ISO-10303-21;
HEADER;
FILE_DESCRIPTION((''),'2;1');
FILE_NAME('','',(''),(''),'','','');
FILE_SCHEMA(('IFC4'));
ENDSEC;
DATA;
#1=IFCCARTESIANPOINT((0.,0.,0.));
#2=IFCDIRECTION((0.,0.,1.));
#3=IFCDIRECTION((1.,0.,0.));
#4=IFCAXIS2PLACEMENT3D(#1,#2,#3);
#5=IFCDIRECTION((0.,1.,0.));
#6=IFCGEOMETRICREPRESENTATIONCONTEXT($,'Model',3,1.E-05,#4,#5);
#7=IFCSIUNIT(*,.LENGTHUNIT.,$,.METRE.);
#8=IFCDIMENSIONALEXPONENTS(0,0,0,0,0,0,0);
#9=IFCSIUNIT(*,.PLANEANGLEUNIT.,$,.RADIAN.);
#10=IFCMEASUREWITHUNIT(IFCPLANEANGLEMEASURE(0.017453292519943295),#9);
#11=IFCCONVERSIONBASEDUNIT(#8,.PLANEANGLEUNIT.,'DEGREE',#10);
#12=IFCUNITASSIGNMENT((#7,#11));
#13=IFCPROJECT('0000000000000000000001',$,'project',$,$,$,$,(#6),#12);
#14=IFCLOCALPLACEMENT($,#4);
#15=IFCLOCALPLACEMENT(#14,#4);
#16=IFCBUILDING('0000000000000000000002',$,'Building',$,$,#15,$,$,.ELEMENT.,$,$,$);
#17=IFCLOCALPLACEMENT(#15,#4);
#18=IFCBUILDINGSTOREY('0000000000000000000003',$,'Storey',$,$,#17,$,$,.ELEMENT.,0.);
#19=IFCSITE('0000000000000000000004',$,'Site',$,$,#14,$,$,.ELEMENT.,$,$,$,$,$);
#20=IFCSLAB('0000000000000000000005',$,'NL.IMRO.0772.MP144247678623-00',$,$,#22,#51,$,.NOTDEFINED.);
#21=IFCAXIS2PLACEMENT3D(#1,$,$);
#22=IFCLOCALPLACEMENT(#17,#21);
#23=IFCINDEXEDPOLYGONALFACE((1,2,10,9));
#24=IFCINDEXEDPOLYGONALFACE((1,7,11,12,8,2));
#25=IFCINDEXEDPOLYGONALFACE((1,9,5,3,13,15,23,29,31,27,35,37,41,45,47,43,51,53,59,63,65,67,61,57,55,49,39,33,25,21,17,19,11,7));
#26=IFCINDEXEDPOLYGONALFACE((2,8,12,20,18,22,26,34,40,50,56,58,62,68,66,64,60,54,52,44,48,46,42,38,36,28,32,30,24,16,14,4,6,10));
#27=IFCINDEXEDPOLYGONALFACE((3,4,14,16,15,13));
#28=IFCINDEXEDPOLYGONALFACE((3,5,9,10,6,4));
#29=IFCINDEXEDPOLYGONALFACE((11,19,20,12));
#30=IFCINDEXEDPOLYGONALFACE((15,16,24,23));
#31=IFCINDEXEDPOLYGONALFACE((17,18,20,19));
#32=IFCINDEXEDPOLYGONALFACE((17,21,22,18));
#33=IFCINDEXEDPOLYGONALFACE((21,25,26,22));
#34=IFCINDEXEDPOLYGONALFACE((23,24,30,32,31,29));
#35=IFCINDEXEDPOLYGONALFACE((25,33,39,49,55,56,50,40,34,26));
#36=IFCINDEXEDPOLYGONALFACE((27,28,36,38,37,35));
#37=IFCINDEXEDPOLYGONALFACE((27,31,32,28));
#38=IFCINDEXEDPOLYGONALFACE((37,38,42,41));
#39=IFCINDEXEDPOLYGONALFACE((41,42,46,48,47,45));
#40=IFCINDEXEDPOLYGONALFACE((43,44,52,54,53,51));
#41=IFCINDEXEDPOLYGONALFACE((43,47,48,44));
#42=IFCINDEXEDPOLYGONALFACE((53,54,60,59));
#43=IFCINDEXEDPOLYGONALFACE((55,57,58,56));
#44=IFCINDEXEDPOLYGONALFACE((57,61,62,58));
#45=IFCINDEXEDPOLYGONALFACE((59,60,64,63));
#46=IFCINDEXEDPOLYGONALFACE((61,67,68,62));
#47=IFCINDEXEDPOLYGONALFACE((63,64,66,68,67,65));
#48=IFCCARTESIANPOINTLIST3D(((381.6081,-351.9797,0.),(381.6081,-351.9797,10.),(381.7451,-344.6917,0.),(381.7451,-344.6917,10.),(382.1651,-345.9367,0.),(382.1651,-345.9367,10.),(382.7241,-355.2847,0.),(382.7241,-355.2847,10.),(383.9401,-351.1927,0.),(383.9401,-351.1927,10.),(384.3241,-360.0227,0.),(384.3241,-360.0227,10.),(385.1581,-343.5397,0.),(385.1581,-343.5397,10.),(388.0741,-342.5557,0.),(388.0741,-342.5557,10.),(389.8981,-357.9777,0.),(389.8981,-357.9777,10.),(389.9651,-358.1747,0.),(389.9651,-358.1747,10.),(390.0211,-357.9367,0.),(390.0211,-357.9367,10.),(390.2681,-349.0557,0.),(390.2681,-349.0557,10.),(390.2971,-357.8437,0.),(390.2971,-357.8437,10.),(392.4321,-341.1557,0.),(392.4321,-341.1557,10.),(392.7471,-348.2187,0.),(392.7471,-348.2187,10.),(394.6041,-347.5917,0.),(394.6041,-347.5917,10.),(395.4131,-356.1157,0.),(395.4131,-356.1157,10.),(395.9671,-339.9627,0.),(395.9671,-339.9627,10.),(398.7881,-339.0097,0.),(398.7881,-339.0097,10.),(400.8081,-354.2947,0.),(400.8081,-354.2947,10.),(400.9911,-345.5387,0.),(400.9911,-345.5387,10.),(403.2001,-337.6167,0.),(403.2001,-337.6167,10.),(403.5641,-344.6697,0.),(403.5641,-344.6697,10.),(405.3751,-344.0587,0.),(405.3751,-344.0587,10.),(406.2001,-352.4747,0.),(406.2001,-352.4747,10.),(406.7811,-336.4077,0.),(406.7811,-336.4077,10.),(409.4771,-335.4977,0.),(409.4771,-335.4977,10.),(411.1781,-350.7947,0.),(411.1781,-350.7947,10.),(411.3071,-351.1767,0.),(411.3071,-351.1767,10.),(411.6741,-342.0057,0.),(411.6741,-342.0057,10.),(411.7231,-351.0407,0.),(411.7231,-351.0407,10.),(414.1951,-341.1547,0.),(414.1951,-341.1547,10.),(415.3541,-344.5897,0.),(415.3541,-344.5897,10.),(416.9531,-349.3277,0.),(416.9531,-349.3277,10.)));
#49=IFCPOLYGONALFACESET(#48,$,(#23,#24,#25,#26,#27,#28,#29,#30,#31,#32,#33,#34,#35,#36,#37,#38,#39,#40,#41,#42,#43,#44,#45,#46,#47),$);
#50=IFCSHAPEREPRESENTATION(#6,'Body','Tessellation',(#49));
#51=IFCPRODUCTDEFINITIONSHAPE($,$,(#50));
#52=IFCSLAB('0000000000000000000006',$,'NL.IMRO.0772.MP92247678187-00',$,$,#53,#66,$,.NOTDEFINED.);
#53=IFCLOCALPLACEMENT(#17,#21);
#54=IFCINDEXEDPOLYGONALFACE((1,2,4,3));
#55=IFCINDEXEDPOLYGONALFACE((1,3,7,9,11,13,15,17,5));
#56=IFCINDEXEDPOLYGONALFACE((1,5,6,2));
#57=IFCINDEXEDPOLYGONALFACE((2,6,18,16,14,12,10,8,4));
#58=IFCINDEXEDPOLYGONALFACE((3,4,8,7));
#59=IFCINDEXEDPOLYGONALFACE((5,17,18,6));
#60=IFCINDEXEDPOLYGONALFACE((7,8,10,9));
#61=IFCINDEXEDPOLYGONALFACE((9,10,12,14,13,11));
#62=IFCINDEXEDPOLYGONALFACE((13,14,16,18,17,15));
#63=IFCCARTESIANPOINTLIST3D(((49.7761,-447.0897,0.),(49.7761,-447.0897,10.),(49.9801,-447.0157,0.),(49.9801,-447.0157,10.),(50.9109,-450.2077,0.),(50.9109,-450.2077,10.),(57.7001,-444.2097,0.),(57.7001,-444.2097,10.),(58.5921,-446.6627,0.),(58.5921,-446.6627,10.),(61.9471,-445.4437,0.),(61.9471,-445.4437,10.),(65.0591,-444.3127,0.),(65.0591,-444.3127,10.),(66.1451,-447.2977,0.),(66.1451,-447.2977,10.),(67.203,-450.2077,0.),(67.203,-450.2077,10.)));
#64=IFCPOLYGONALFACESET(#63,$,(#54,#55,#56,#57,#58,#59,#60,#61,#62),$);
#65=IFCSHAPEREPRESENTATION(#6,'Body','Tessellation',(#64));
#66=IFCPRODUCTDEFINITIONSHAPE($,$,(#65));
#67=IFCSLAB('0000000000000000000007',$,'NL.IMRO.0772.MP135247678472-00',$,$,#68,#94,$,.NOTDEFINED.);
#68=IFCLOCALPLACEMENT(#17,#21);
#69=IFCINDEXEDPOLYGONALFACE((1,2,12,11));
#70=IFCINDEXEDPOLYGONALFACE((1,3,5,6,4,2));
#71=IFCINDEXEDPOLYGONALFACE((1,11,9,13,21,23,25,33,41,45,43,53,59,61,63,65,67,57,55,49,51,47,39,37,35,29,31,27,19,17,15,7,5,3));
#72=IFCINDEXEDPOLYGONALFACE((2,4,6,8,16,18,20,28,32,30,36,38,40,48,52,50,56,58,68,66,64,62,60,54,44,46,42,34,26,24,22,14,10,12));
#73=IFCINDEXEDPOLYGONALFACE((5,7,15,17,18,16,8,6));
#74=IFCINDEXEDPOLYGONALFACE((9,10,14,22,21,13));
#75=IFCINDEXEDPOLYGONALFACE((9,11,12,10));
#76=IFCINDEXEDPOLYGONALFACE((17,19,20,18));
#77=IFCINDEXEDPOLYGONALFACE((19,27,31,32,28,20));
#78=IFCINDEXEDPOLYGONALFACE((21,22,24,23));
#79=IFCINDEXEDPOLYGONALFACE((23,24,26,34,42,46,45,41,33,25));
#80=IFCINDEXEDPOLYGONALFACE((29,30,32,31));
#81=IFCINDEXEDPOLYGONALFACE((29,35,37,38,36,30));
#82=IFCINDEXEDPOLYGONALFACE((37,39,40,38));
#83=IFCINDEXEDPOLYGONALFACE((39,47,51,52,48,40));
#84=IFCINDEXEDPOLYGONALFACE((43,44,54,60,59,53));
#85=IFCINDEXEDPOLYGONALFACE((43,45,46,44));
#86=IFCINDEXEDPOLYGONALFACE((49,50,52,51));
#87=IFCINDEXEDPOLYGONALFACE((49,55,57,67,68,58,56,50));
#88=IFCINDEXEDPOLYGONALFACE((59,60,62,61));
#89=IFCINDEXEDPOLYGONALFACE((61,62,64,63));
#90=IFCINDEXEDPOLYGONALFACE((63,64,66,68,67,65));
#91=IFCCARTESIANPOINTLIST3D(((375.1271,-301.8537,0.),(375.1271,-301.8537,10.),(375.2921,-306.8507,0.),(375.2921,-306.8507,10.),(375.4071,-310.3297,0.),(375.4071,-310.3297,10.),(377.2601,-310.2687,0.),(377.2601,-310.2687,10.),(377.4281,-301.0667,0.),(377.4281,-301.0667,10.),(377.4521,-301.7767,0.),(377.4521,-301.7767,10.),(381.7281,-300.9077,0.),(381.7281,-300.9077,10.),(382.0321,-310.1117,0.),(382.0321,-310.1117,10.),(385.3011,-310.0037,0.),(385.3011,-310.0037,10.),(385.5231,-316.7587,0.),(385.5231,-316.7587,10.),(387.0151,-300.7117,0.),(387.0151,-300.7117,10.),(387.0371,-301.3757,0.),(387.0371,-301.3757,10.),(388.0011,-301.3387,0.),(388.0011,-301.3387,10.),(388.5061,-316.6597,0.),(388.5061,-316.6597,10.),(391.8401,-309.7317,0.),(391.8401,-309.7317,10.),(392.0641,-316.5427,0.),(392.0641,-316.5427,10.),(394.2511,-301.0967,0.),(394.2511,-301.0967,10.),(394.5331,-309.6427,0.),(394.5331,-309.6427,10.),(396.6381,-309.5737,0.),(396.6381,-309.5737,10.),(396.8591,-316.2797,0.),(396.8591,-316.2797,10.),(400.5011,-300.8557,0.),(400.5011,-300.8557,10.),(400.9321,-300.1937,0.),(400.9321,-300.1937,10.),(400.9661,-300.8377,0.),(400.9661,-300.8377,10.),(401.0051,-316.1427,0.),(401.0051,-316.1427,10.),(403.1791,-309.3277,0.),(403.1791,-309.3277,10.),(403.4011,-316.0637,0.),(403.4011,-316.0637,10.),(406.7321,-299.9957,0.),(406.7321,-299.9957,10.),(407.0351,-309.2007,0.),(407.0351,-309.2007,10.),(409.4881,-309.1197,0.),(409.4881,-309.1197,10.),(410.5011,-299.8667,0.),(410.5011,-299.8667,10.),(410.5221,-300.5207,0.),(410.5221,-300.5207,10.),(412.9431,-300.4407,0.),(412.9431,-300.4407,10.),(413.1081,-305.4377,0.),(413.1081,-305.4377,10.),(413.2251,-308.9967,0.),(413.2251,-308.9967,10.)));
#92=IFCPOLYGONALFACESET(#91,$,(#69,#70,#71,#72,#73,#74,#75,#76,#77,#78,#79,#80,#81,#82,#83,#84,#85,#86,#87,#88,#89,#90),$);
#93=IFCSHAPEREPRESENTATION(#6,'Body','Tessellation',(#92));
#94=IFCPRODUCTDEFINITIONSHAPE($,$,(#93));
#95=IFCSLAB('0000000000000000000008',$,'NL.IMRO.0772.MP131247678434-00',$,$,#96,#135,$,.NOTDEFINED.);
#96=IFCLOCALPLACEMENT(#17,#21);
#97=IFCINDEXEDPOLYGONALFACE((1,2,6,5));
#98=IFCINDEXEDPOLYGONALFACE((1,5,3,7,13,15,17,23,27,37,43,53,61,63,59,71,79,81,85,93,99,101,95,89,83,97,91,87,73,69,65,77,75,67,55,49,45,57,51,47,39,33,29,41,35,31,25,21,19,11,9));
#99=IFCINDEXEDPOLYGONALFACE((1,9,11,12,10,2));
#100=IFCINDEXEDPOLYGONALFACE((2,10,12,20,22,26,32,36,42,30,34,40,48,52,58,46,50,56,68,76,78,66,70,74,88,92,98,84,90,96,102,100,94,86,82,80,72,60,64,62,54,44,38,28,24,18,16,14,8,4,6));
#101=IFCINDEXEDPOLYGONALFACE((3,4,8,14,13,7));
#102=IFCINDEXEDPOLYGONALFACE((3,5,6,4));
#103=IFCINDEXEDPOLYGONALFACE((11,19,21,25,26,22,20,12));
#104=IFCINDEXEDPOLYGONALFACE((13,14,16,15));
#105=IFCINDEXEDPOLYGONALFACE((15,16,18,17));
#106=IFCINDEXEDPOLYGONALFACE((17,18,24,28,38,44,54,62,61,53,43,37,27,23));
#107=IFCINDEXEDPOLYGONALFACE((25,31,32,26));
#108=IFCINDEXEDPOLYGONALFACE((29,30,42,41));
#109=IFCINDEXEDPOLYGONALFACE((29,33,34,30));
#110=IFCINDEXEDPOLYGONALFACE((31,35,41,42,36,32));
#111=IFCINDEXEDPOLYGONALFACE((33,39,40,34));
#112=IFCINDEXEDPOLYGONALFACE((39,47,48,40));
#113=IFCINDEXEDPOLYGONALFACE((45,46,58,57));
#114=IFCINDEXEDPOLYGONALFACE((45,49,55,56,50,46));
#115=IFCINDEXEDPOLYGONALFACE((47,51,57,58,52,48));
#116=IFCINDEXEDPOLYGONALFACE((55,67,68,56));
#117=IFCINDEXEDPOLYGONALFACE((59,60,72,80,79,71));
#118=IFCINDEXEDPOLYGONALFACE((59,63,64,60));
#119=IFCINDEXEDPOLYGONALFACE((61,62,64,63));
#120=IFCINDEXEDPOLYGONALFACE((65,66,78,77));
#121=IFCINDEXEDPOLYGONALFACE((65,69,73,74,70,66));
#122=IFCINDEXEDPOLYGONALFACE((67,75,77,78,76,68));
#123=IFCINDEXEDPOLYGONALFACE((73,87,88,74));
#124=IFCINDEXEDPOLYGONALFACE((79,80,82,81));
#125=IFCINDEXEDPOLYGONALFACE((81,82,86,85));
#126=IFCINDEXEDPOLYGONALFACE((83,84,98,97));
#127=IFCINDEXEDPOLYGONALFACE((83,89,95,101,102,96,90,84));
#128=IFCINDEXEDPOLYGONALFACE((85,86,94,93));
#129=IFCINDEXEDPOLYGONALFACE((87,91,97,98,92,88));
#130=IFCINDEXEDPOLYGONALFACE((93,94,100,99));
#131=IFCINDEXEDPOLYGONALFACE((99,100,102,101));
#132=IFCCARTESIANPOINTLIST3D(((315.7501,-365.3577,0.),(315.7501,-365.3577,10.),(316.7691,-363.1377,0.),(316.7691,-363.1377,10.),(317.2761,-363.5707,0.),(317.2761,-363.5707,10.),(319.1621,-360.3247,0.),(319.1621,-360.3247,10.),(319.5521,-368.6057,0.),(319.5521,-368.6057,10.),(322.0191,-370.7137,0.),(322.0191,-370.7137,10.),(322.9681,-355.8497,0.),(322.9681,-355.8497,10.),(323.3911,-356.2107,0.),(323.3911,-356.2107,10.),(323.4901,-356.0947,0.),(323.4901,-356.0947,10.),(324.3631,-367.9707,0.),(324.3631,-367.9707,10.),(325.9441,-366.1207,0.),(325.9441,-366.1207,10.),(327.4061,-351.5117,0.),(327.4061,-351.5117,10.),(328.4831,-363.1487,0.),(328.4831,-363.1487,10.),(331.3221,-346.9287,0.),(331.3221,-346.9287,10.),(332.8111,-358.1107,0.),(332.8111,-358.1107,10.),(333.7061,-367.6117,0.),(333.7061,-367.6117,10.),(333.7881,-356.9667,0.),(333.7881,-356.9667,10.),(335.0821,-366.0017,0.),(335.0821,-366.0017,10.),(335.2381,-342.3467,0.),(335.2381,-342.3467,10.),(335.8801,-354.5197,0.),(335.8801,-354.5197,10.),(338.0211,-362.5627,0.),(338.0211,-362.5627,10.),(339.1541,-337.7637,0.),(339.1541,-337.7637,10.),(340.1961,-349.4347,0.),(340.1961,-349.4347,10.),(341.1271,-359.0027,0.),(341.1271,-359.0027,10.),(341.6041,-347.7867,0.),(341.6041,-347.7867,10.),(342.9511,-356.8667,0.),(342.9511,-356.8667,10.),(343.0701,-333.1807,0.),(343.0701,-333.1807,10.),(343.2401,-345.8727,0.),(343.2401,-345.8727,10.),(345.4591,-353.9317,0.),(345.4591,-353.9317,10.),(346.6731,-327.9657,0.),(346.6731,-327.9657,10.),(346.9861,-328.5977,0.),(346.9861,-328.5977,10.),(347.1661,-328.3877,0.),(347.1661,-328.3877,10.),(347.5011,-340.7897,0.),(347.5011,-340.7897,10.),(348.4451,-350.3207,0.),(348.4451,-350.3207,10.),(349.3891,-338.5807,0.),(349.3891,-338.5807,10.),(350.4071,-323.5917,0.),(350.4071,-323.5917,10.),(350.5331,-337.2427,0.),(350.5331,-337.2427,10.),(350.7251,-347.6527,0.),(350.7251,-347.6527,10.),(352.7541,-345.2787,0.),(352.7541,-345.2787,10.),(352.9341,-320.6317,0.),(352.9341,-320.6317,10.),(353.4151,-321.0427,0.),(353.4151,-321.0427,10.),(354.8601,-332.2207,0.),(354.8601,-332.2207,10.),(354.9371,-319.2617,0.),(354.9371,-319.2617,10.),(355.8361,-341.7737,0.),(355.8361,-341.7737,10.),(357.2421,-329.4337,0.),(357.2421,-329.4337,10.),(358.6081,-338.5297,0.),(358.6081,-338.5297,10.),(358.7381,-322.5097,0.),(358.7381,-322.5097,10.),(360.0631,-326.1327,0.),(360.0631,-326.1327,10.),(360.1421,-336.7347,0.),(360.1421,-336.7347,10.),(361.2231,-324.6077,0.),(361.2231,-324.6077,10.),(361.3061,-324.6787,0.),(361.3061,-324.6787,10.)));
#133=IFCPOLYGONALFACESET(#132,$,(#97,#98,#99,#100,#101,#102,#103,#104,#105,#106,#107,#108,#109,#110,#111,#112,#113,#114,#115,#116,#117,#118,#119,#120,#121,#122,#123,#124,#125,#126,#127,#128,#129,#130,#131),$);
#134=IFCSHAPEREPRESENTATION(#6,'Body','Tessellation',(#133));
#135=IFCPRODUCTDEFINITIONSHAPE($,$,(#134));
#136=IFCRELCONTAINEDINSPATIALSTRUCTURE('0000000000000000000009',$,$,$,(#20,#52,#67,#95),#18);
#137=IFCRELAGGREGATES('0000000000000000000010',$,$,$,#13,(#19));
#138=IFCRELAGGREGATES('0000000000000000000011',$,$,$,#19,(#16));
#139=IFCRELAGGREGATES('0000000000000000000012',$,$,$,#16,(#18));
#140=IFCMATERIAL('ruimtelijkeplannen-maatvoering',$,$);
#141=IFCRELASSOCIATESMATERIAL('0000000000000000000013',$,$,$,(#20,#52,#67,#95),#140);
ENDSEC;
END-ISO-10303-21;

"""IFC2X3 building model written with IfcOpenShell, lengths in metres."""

from ifc_helpers import new_model, entity, si_unit, converted_unit, direction, origin_with_axes, place, context, project, spatial, polyline, outline, extrude, material, element, save


model = new_model("IFC2X3")

# Units and contexts
model_context = context("Model", 3, precision=1e-05, world=origin_with_axes(), true_north=direction((0.0, 1.0, 0.0)))
ifc_project = project(units=[si_unit("LENGTHUNIT", "METRE"), converted_unit("PLANEANGLEUNIT", "DEGREE", entity("IfcPlaneAngleMeasure", 0.017453292519943295), si_unit("PLANEANGLEUNIT", "RADIAN"), dimensions=[0, 0, 0, 0, 0, 0, 0])], contexts=[model_context])

# Site, building, storey
site_placement = place(None, origin_with_axes())
site = spatial("IfcSite", under=ifc_project, at=site_placement, Name="Site", CompositionType="ELEMENT")
building_placement = place(site_placement, origin_with_axes())
building = spatial("IfcBuilding", under=site, at=building_placement, Name="Building", CompositionType="ELEMENT")
storey_placement = place(building_placement, origin_with_axes())
storey = spatial("IfcBuildingStorey", under=building, at=storey_placement, Name="Storey", CompositionType="ELEMENT", Elevation=0.0)

# Slabs
ifc_material = material(Name="ruimtelijkeplannen-maatvoering")
slab_1_placement = place(storey_placement, origin_with_axes())
element("IfcSlab", 1, at=slab_1_placement, inside=storey, material=ifc_material, Name="NL.IMRO.0772.MP144247678623-00", PredefinedType="NOTDEFINED", context=model_context, shape_type="SweptSolid", body=[
    extrude(outline(polyline([(395.4131, -356.1157), (390.2971, -357.8437), (390.0211, -357.9367), (389.8981, -357.9777), (389.9651, -358.1747), (384.3241, -360.0227), (382.7241, -355.2847), (381.6081, -351.9797), (383.9401, -351.1927), (382.1651, -345.9367), (381.7451, -344.6917), (385.1581, -343.5397), (388.0741, -342.5557), (390.2681, -349.0557), (392.7471, -348.2187), (394.6041, -347.5917), (392.4321, -341.1557), (395.9671, -339.9627), (398.7881, -339.0097), (400.9911, -345.5387), (403.5641, -344.6697), (405.3751, -344.0587), (403.2001, -337.6167), (406.7811, -336.4077), (409.4771, -335.4977), (411.6741, -342.0057), (414.1951, -341.1547), (415.3541, -344.5897), (416.9531, -349.3277), (411.7231, -351.0407), (411.3071, -351.1767), (411.1781, -350.7947), (406.2001, -352.4747), (400.8081, -354.2947), (395.4131, -356.1157)])), origin_with_axes(), (0.0, 0.0, 1.0), 10.0),
])
slab_2_placement = place(storey_placement, origin_with_axes())
element("IfcSlab", 2, at=slab_2_placement, inside=storey, material=ifc_material, Name="NL.IMRO.0772.MP92247678187-00", PredefinedType="NOTDEFINED", context=model_context, shape_type="SweptSolid", body=[
    extrude(outline(polyline([(49.7761, -447.0897), (49.9801, -447.0157), (57.7001, -444.2097), (58.5921, -446.6627), (61.9471, -445.4437), (65.0591, -444.3127), (66.1451, -447.2977), (67.203, -450.2077), (50.9109, -450.2077), (49.7761, -447.0897)])), origin_with_axes(), (0.0, 0.0, 1.0), 10.0),
])
slab_3_placement = place(storey_placement, origin_with_axes())
element("IfcSlab", 3, at=slab_3_placement, inside=storey, material=ifc_material, Name="NL.IMRO.0772.MP135247678472-00", PredefinedType="NOTDEFINED", context=model_context, shape_type="SweptSolid", body=[
    extrude(outline(polyline([(375.4071, -310.3297), (375.2921, -306.8507), (375.1271, -301.8537), (377.4521, -301.7767), (377.4281, -301.0667), (381.7281, -300.9077), (387.0151, -300.7117), (387.0371, -301.3757), (388.0011, -301.3387), (394.2511, -301.0967), (400.5011, -300.8557), (400.9661, -300.8377), (400.9321, -300.1937), (406.7321, -299.9957), (410.5011, -299.8667), (410.5221, -300.5207), (412.9431, -300.4407), (413.1081, -305.4377), (413.2251, -308.9967), (409.4881, -309.1197), (407.0351, -309.2007), (403.1791, -309.3277), (403.4011, -316.0637), (401.0051, -316.1427), (396.8591, -316.2797), (396.6381, -309.5737), (394.5331, -309.6427), (391.8401, -309.7317), (392.0641, -316.5427), (388.5061, -316.6597), (385.5231, -316.7587), (385.3011, -310.0037), (382.0321, -310.1117), (377.2601, -310.2687), (375.4071, -310.3297)])), origin_with_axes(), (0.0, 0.0, 1.0), 10.0),
])
slab_4_placement = place(storey_placement, origin_with_axes())
element("IfcSlab", 4, at=slab_4_placement, inside=storey, material=ifc_material, Name="NL.IMRO.0772.MP131247678434-00", PredefinedType="NOTDEFINED", context=model_context, shape_type="SweptSolid", body=[
    extrude(outline(polyline([(339.1541, -337.7637), (343.0701, -333.1807), (346.9861, -328.5977), (347.1661, -328.3877), (346.6731, -327.9657), (350.4071, -323.5917), (352.9341, -320.6317), (353.4151, -321.0427), (354.9371, -319.2617), (358.7381, -322.5097), (361.2231, -324.6077), (361.3061, -324.6787), (360.0631, -326.1327), (357.2421, -329.4337), (354.8601, -332.2207), (360.1421, -336.7347), (358.6081, -338.5297), (355.8361, -341.7737), (350.5331, -337.2427), (349.3891, -338.5807), (347.5011, -340.7897), (352.7541, -345.2787), (350.7251, -347.6527), (348.4451, -350.3207), (343.2401, -345.8727), (341.6041, -347.7867), (340.1961, -349.4347), (345.4591, -353.9317), (342.9511, -356.8667), (341.1271, -359.0027), (335.8801, -354.5197), (333.7881, -356.9667), (332.8111, -358.1107), (338.0211, -362.5627), (335.0821, -366.0017), (333.7061, -367.6117), (328.4831, -363.1487), (325.9441, -366.1207), (324.3631, -367.9707), (322.0191, -370.7137), (319.5521, -368.6057), (315.7501, -365.3577), (317.2761, -363.5707), (316.7691, -363.1377), (319.1621, -360.3247), (322.9681, -355.8497), (323.3911, -356.2107), (323.4901, -356.0947), (327.4061, -351.5117), (331.3221, -346.9287), (335.2381, -342.3467), (339.1541, -337.7637)])), origin_with_axes(), (0.0, 0.0, 1.0), 10.0),
])

save(model, "model.ifc")
